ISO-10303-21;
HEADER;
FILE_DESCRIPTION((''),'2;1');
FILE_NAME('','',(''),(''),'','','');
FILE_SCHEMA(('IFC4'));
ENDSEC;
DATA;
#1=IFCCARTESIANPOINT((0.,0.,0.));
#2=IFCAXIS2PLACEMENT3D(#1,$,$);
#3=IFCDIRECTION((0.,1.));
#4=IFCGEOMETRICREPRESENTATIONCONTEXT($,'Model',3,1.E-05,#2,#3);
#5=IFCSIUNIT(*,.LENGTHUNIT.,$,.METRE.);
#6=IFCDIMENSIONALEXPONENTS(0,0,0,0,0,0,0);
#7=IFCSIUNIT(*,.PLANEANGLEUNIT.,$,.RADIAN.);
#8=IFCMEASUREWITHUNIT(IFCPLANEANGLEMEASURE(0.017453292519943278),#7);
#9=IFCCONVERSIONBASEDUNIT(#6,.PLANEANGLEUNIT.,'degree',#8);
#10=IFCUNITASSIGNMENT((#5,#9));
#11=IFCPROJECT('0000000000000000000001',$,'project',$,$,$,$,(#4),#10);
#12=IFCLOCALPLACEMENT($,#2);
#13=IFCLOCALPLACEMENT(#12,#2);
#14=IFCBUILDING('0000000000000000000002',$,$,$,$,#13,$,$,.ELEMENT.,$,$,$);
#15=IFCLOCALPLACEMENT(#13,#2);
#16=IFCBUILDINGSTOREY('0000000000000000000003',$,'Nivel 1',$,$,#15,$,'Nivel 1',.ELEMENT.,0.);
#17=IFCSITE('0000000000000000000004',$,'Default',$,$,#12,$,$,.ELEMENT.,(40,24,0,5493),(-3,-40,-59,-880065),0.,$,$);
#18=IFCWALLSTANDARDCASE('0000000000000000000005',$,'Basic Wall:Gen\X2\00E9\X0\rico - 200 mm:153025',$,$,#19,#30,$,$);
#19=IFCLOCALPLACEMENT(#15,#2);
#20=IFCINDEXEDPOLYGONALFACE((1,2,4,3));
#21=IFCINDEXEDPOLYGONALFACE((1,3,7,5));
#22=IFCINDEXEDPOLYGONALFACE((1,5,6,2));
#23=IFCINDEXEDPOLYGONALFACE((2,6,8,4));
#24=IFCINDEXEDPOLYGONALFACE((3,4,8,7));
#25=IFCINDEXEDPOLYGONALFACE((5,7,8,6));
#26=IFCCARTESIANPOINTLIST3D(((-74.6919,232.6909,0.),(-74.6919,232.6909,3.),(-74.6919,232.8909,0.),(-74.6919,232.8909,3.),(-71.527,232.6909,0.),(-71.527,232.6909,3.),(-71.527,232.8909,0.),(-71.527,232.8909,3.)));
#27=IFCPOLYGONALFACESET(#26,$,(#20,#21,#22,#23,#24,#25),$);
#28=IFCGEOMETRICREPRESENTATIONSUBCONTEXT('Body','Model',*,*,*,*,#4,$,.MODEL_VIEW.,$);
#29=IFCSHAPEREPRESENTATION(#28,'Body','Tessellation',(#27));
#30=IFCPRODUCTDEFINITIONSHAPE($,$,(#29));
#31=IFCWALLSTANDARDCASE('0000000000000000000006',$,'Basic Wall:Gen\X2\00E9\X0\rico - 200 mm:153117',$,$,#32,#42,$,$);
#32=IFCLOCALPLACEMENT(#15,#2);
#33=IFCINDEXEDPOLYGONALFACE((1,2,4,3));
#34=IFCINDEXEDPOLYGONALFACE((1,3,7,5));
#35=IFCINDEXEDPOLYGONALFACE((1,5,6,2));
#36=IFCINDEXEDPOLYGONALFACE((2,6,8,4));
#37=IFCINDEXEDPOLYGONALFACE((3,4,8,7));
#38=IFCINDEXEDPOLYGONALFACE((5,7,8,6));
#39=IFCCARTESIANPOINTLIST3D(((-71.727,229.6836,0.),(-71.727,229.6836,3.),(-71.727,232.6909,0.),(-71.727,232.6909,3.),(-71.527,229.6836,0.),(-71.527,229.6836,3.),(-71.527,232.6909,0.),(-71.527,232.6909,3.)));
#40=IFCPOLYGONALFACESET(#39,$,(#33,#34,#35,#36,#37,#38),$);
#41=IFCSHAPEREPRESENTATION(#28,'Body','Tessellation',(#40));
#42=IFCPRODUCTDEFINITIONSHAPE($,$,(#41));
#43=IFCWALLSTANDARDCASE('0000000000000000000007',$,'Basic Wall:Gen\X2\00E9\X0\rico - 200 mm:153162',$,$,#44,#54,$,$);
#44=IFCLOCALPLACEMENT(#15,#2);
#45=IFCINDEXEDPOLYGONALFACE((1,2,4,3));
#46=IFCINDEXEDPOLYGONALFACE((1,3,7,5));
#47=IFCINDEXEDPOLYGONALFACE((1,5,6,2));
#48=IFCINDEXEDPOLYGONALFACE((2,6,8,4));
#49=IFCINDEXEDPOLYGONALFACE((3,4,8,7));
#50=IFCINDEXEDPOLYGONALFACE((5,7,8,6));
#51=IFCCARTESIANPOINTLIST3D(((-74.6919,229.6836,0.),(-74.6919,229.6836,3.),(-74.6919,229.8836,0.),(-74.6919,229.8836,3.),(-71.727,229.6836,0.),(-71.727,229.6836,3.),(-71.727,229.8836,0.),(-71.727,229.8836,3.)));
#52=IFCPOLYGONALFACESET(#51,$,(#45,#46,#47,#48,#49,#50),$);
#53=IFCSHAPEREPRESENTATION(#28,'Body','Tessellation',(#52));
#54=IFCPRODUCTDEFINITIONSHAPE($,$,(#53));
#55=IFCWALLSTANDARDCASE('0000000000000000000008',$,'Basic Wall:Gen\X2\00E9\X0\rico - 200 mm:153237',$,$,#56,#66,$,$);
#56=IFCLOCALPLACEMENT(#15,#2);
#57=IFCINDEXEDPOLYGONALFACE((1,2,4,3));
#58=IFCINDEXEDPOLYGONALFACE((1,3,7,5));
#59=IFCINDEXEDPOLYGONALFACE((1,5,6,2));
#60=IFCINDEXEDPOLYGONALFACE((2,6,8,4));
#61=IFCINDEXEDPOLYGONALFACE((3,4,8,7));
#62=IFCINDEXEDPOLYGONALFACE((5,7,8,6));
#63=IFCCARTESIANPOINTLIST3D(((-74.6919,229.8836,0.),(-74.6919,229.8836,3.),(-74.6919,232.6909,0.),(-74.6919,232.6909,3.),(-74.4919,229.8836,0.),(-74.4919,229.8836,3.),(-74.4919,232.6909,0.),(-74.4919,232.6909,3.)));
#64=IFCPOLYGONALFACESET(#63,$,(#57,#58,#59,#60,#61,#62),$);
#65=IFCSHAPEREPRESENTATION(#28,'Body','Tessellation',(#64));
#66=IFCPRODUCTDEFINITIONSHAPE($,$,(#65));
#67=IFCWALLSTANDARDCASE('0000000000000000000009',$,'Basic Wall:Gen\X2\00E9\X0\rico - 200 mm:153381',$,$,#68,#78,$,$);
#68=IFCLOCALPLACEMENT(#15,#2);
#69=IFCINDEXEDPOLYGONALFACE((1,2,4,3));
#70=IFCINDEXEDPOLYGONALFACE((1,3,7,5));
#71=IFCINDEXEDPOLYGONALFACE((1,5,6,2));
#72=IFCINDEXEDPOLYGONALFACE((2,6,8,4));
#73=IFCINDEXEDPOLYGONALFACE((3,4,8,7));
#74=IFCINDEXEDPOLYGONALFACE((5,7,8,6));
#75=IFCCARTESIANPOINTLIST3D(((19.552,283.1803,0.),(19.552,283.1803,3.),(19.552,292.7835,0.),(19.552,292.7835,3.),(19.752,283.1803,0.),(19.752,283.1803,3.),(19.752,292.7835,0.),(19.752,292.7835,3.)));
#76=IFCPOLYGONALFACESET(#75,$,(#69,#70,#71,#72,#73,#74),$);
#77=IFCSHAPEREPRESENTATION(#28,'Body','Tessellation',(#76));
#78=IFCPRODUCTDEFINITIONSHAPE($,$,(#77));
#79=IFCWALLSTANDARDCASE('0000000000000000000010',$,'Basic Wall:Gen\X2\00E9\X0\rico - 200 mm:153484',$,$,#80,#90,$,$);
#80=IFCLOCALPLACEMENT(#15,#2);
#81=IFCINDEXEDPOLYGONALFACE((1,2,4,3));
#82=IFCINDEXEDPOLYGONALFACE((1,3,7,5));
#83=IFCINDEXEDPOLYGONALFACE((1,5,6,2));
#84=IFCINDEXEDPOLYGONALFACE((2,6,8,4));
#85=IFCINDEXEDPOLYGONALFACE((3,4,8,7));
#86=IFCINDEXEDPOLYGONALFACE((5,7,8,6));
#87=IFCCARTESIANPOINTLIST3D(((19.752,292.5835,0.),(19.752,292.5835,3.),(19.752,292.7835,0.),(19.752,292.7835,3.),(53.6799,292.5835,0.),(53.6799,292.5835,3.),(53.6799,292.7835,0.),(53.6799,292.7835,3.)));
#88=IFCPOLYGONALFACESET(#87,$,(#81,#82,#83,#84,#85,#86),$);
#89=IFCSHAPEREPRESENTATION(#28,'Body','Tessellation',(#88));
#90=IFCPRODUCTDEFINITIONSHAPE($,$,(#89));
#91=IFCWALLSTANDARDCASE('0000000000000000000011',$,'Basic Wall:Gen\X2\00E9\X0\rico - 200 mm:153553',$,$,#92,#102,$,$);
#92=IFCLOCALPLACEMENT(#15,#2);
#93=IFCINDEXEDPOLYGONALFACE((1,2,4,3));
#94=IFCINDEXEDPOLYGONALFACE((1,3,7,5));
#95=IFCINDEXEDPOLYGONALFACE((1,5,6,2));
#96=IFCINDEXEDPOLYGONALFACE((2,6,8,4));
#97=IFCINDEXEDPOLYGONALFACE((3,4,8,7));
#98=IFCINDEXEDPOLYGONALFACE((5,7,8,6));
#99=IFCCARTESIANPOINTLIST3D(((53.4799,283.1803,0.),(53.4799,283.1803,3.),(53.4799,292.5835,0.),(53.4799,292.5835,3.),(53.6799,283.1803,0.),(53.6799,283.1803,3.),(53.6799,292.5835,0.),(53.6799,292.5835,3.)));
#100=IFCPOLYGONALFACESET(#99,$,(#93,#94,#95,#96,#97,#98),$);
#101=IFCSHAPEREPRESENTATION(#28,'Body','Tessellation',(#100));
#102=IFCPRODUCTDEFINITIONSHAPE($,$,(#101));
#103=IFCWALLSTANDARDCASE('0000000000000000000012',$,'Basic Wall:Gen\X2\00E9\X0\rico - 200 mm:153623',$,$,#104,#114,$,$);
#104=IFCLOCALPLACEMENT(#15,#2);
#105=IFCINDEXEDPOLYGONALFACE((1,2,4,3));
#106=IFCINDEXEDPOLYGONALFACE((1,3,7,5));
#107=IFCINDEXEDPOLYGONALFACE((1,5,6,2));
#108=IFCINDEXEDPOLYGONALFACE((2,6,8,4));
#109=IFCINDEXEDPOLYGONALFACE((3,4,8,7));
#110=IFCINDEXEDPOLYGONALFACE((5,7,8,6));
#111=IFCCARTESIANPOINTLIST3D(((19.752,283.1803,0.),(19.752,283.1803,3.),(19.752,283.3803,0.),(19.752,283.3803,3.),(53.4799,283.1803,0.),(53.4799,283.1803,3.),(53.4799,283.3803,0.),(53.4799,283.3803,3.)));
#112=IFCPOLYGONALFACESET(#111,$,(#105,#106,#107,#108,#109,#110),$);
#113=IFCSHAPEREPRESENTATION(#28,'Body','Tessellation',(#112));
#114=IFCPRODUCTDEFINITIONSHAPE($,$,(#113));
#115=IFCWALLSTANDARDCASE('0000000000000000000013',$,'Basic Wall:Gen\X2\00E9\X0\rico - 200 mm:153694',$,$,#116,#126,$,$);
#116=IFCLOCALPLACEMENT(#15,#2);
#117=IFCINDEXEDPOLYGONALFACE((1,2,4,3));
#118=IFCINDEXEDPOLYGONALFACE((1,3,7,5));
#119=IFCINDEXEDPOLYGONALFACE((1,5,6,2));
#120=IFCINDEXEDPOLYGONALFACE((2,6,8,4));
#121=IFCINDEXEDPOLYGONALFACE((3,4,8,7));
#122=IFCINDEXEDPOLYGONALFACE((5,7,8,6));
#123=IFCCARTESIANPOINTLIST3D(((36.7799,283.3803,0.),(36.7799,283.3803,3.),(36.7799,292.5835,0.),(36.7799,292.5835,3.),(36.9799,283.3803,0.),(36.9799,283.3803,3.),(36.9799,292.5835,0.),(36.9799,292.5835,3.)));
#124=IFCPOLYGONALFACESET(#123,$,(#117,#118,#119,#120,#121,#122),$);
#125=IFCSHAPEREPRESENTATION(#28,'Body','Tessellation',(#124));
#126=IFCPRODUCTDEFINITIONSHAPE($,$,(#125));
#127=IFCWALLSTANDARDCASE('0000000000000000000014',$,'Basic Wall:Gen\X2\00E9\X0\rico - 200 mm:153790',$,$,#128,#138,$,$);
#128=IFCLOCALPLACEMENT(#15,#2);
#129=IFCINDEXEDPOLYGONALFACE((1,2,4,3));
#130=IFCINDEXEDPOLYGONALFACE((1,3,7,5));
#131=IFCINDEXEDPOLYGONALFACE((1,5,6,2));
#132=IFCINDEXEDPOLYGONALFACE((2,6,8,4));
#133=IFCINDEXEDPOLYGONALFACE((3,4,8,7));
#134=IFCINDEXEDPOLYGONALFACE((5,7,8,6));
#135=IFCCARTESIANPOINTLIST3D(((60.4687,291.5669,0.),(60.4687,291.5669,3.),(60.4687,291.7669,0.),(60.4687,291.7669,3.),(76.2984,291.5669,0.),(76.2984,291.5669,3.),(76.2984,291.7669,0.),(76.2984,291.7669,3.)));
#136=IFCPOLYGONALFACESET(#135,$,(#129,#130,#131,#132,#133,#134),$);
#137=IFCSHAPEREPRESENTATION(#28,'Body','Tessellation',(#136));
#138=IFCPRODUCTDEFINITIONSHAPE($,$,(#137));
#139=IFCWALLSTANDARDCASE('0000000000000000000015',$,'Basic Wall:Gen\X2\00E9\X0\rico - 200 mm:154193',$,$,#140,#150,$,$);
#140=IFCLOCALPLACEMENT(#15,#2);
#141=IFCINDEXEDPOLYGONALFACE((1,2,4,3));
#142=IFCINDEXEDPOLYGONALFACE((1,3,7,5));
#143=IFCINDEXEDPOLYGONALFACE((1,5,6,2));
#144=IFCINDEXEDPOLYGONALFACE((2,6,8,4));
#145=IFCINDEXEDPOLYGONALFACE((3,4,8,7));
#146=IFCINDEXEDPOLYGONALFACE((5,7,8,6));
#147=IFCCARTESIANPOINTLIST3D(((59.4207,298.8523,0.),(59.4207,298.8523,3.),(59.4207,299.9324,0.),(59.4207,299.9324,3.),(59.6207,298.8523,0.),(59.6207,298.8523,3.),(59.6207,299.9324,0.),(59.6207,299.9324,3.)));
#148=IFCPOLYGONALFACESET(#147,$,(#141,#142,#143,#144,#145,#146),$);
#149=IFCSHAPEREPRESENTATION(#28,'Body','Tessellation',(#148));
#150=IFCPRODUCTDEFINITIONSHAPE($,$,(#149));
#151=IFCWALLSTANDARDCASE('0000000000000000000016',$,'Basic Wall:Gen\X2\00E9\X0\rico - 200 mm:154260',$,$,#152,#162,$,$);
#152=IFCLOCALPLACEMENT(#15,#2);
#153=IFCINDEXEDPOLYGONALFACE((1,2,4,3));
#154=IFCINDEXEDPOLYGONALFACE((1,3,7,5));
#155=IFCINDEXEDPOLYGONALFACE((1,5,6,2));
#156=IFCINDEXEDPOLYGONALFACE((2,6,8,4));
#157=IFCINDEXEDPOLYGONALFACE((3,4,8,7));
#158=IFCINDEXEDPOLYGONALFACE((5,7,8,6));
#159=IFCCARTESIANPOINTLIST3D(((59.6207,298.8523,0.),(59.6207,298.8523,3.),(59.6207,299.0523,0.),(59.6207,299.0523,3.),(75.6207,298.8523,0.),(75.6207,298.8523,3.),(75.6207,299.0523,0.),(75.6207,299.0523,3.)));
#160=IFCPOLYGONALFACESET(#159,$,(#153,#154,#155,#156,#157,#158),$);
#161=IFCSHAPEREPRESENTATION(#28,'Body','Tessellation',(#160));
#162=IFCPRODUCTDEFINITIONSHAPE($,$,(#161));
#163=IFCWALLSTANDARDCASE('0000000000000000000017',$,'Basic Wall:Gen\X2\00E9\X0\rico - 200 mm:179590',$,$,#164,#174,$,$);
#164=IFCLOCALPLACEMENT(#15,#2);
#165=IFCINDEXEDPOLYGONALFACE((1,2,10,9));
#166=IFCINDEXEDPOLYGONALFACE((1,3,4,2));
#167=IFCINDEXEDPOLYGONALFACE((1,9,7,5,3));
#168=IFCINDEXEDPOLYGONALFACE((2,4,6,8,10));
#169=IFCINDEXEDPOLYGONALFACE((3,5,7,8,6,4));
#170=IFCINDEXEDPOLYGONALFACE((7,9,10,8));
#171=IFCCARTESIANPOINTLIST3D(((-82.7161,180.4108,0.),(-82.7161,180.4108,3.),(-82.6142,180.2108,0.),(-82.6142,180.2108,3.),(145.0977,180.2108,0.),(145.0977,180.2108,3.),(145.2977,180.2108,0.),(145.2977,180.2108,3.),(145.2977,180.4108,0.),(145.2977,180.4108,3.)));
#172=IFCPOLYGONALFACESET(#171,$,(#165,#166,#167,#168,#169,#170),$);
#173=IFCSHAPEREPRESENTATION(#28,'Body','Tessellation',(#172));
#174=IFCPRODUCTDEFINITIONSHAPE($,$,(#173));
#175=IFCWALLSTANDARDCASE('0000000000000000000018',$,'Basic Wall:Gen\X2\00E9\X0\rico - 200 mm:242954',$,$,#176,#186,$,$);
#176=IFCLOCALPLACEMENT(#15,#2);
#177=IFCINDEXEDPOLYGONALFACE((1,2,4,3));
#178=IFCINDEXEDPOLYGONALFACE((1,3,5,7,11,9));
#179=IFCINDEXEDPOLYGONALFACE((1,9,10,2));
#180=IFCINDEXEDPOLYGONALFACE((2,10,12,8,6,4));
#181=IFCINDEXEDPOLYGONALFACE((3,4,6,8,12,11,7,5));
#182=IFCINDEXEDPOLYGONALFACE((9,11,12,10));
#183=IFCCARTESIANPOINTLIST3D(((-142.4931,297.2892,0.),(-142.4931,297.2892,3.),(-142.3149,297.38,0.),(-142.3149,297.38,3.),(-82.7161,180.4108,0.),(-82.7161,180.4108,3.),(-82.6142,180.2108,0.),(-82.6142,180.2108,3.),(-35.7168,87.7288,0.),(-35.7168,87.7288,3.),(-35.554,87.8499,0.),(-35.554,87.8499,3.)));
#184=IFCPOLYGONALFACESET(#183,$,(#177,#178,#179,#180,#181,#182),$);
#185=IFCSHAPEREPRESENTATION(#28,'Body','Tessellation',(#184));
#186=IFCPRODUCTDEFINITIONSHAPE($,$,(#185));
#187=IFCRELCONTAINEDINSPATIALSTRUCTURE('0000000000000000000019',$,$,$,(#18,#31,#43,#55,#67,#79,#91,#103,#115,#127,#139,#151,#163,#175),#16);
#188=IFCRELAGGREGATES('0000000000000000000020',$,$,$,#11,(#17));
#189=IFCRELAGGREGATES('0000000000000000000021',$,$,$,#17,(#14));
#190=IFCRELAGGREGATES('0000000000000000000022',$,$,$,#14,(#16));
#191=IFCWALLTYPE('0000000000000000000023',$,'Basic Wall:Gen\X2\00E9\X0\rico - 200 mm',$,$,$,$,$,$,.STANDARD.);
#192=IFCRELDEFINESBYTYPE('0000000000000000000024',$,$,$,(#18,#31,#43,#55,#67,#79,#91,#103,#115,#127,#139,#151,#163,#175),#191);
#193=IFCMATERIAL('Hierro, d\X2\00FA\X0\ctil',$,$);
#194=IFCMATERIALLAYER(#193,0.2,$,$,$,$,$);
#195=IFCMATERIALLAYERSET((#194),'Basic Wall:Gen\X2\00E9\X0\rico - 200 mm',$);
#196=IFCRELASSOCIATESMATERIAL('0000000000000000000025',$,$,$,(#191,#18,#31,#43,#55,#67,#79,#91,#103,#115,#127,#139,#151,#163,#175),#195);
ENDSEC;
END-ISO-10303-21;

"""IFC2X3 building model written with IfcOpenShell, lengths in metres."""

from ifc_helpers import new_model, entity, si_unit, converted_unit, direction, frame, frame_2d, origin, place, context, subcontext, project, spatial, polyline, rectangle, outline, extrude, material, layer, layer_set, layer_usage, type_object, element, save


model = new_model("IFC2X3")

# Units and contexts
model_context = context("Model", 3, precision=1e-05, world=origin(), true_north=direction((0.0, 1.0)))
body_context = subcontext(model_context, "Body", "Model", "MODEL_VIEW")
ifc_project = project(units=[si_unit("LENGTHUNIT", "METRE"), converted_unit("PLANEANGLEUNIT", "degree", entity("IfcPlaneAngleMeasure", 0.017453292519943278), si_unit("PLANEANGLEUNIT", "RADIAN"), dimensions=[0, 0, 0, 0, 0, 0, 0])], contexts=[model_context])

# Site, building, storey
site_placement = place(None, origin())
site = spatial("IfcSite", under=ifc_project, at=site_placement, Name="Default", CompositionType="ELEMENT", RefLatitude=(40, 24, 0, 5493), RefLongitude=(-3, -40, -59, -880065), RefElevation=0.0)
building_placement = place(site_placement, origin())
building = spatial("IfcBuilding", under=site, at=building_placement, CompositionType="ELEMENT")
storey_placement = place(building_placement, origin())
storey = spatial("IfcBuildingStorey", under=building, at=storey_placement, Name="Nivel 1", LongName="Nivel 1", CompositionType="ELEMENT", Elevation=0.0)

# Walls
ifc_material_1 = material(Name="Hierro, dúctil")
ifc_layer_1 = layer(ifc_material_1, 0.2)
ifc_layer_set_1 = layer_set([ifc_layer_1], Name="Basic Wall:Genérico - 200 mm")
ifc_layer_usage_1 = layer_usage(ifc_layer_set_1, "AXIS2", "NEGATIVE", 0.1)
wall_type = type_object("IfcWallType", Name="Basic Wall:Genérico - 200 mm", PredefinedType="STANDARD", material=ifc_layer_set_1)
wall_1_placement = place(storey_placement, frame((-74.6919, 232.7909, 0.0)))
element("IfcWallStandardCase", 1, at=wall_1_placement, inside=storey, type_object=wall_type, material=ifc_layer_usage_1, Name="Basic Wall:Genérico - 200 mm:153025", context=body_context, shape_type="SweptSolid", body=[
    extrude(rectangle(XDim=3.165, YDim=0.2, at=frame_2d((1.5825, 0.0), x_axis=(-1.0, 0.0))), origin(), (0.0, 0.0, 1.0), 3.0),
])
ifc_layer_usage_2 = layer_usage(ifc_layer_set_1, "AXIS2", "NEGATIVE", 0.1)
wall_2_placement = place(storey_placement, frame((-71.627, 232.6909, 0.0), z_axis=(0.0, 0.0, 1.0), x_axis=(0.0, -1.0, 0.0)))
element("IfcWallStandardCase", 2, at=wall_2_placement, inside=storey, type_object=wall_type, material=ifc_layer_usage_2, Name="Basic Wall:Genérico - 200 mm:153117", context=body_context, shape_type="SweptSolid", body=[
    extrude(rectangle(XDim=3.0073, YDim=0.2, at=frame_2d((1.5037, 0.0), x_axis=(-1.0, 0.0))), origin(), (0.0, 0.0, 1.0), 3.0),
])
ifc_layer_usage_3 = layer_usage(ifc_layer_set_1, "AXIS2", "NEGATIVE", 0.1)
wall_3_placement = place(storey_placement, frame((-71.727, 229.7836, 0.0), z_axis=(0.0, 0.0, 1.0), x_axis=(-1.0, 0.0, 0.0)))
element("IfcWallStandardCase", 3, at=wall_3_placement, inside=storey, type_object=wall_type, material=ifc_layer_usage_3, Name="Basic Wall:Genérico - 200 mm:153162", context=body_context, shape_type="SweptSolid", body=[
    extrude(rectangle(XDim=2.965, YDim=0.2, at=frame_2d((1.4825, 0.0), x_axis=(-1.0, 0.0))), origin(), (0.0, 0.0, 1.0), 3.0),
])
ifc_layer_usage_4 = layer_usage(ifc_layer_set_1, "AXIS2", "NEGATIVE", 0.1)
wall_4_placement = place(storey_placement, frame((-74.5919, 229.8836, 0.0), z_axis=(0.0, 0.0, 1.0), x_axis=(0.0, 1.0, 0.0)))
element("IfcWallStandardCase", 4, at=wall_4_placement, inside=storey, type_object=wall_type, material=ifc_layer_usage_4, Name="Basic Wall:Genérico - 200 mm:153237", context=body_context, shape_type="SweptSolid", body=[
    extrude(rectangle(XDim=2.8073, YDim=0.2, at=frame_2d((1.4037, 0.0), x_axis=(-1.0, 0.0))), origin(), (0.0, 0.0, 1.0), 3.0),
])
ifc_layer_usage_5 = layer_usage(ifc_layer_set_1, "AXIS2", "NEGATIVE", 0.1)
wall_5_placement = place(storey_placement, frame((19.652, 283.1803, 0.0), z_axis=(0.0, 0.0, 1.0), x_axis=(0.0, 1.0, 0.0)))
element("IfcWallStandardCase", 5, at=wall_5_placement, inside=storey, type_object=wall_type, material=ifc_layer_usage_5, Name="Basic Wall:Genérico - 200 mm:153381", context=body_context, shape_type="SweptSolid", body=[
    extrude(rectangle(XDim=9.6032, YDim=0.2, at=frame_2d((4.8016, 0.0), x_axis=(-1.0, 0.0))), origin(), (0.0, 0.0, 1.0), 3.0),
])
ifc_layer_usage_6 = layer_usage(ifc_layer_set_1, "AXIS2", "NEGATIVE", 0.1)
wall_6_placement = place(storey_placement, frame((19.752, 292.6835, 0.0)))
element("IfcWallStandardCase", 6, at=wall_6_placement, inside=storey, type_object=wall_type, material=ifc_layer_usage_6, Name="Basic Wall:Genérico - 200 mm:153484", context=body_context, shape_type="SweptSolid", body=[
    extrude(rectangle(XDim=33.9278, YDim=0.2, at=frame_2d((16.9639, 0.0), x_axis=(-1.0, 0.0))), origin(), (0.0, 0.0, 1.0), 3.0),
])
ifc_layer_usage_7 = layer_usage(ifc_layer_set_1, "AXIS2", "NEGATIVE", 0.1)
wall_7_placement = place(storey_placement, frame((53.5799, 292.5835, 0.0), z_axis=(0.0, 0.0, 1.0), x_axis=(0.0, -1.0, 0.0)))
element("IfcWallStandardCase", 7, at=wall_7_placement, inside=storey, type_object=wall_type, material=ifc_layer_usage_7, Name="Basic Wall:Genérico - 200 mm:153553", context=body_context, shape_type="SweptSolid", body=[
    extrude(rectangle(XDim=9.4032, YDim=0.2, at=frame_2d((4.7016, 0.0), x_axis=(-1.0, 0.0))), origin(), (0.0, 0.0, 1.0), 3.0),
])
ifc_layer_usage_8 = layer_usage(ifc_layer_set_1, "AXIS2", "NEGATIVE", 0.1)
wall_8_placement = place(storey_placement, frame((53.4799, 283.2803, 0.0), z_axis=(0.0, 0.0, 1.0), x_axis=(-1.0, 0.0, 0.0)))
element("IfcWallStandardCase", 8, at=wall_8_placement, inside=storey, type_object=wall_type, material=ifc_layer_usage_8, Name="Basic Wall:Genérico - 200 mm:153623", context=body_context, shape_type="SweptSolid", body=[
    extrude(rectangle(XDim=33.7278, YDim=0.2, at=frame_2d((16.8639, 0.0), x_axis=(-1.0, 0.0))), origin(), (0.0, 0.0, 1.0), 3.0),
])
ifc_layer_usage_9 = layer_usage(ifc_layer_set_1, "AXIS2", "NEGATIVE", 0.1)
wall_9_placement = place(storey_placement, frame((36.8799, 292.5835, 0.0), z_axis=(0.0, 0.0, 1.0), x_axis=(0.0, -1.0, 0.0)))
element("IfcWallStandardCase", 9, at=wall_9_placement, inside=storey, type_object=wall_type, material=ifc_layer_usage_9, Name="Basic Wall:Genérico - 200 mm:153694", context=body_context, shape_type="SweptSolid", body=[
    extrude(rectangle(XDim=9.2032, YDim=0.2, at=frame_2d((4.6016, 0.0), x_axis=(-1.0, 0.0))), origin(), (0.0, 0.0, 1.0), 3.0),
])
ifc_layer_usage_10 = layer_usage(ifc_layer_set_1, "AXIS2", "NEGATIVE", 0.1)
wall_10_placement = place(storey_placement, frame((60.4687, 291.6669, 0.0)))
element("IfcWallStandardCase", 10, at=wall_10_placement, inside=storey, type_object=wall_type, material=ifc_layer_usage_10, Name="Basic Wall:Genérico - 200 mm:153790", context=body_context, shape_type="SweptSolid", body=[
    extrude(rectangle(XDim=15.8297, YDim=0.2, at=frame_2d((7.9148, 0.0), x_axis=(-1.0, 0.0))), origin(), (0.0, 0.0, 1.0), 3.0),
])
ifc_layer_usage_11 = layer_usage(ifc_layer_set_1, "AXIS2", "NEGATIVE", 0.1)
wall_11_placement = place(storey_placement, frame((59.5207, 299.9324, 0.0), z_axis=(0.0, 0.0, 1.0), x_axis=(0.0, -1.0, 0.0)))
element("IfcWallStandardCase", 11, at=wall_11_placement, inside=storey, type_object=wall_type, material=ifc_layer_usage_11, Name="Basic Wall:Genérico - 200 mm:154193", context=body_context, shape_type="SweptSolid", body=[
    extrude(rectangle(XDim=1.0801, YDim=0.2, at=frame_2d((0.54, 0.0), x_axis=(-1.0, 0.0))), origin(), (0.0, 0.0, 1.0), 3.0),
])
ifc_layer_usage_12 = layer_usage(ifc_layer_set_1, "AXIS2", "NEGATIVE", 0.1)
wall_12_placement = place(storey_placement, frame((59.6207, 298.9523, 0.0)))
element("IfcWallStandardCase", 12, at=wall_12_placement, inside=storey, type_object=wall_type, material=ifc_layer_usage_12, Name="Basic Wall:Genérico - 200 mm:154260", context=body_context, shape_type="SweptSolid", body=[
    extrude(rectangle(XDim=16.0, YDim=0.2, at=frame_2d((8.0, 0.0), x_axis=(-1.0, 0.0))), origin(), (0.0, 0.0, 1.0), 3.0),
])
ifc_layer_usage_13 = layer_usage(ifc_layer_set_1, "AXIS2", "NEGATIVE", 0.1)
wall_13_placement = place(storey_placement, frame((-82.7161, 180.3108, 0.0)))
element("IfcWallStandardCase", 13, at=wall_13_placement, inside=storey, type_object=wall_type, material=ifc_layer_usage_13, Name="Basic Wall:Genérico - 200 mm:179590", context=body_context, shape_type="SweptSolid", body=[
    extrude(outline(polyline([(228.0138, -0.1), (228.0138, 0.1), (0.0, 0.1), (0.1019, -0.1), (227.8138, -0.1), (228.0138, -0.1)])), origin(), (0.0, 0.0, 1.0), 3.0),
])
ifc_layer_usage_14 = layer_usage(ifc_layer_set_1, "AXIS2", "NEGATIVE", 0.1)
wall_14_placement = place(storey_placement, frame((-142.404, 297.3346, 0.0), z_axis=(0.0, 0.0, 1.0), x_axis=(0.45399, -0.891007, 0.0)))
element("IfcWallStandardCase", 14, at=wall_14_placement, inside=storey, type_object=wall_type, material=ifc_layer_usage_14, Name="Basic Wall:Genérico - 200 mm:242954", context=body_context, shape_type="SweptSolid", body=[
    extrude(outline(polyline([(235.1951, -0.1), (235.1611, 0.1), (131.5021, 0.1), (131.2776, 0.1), (0.0, 0.1), (0.0, -0.1), (235.1951, -0.1)])), origin(), (0.0, 0.0, 1.0), 3.0),
])

save(model, "model.ifc")
